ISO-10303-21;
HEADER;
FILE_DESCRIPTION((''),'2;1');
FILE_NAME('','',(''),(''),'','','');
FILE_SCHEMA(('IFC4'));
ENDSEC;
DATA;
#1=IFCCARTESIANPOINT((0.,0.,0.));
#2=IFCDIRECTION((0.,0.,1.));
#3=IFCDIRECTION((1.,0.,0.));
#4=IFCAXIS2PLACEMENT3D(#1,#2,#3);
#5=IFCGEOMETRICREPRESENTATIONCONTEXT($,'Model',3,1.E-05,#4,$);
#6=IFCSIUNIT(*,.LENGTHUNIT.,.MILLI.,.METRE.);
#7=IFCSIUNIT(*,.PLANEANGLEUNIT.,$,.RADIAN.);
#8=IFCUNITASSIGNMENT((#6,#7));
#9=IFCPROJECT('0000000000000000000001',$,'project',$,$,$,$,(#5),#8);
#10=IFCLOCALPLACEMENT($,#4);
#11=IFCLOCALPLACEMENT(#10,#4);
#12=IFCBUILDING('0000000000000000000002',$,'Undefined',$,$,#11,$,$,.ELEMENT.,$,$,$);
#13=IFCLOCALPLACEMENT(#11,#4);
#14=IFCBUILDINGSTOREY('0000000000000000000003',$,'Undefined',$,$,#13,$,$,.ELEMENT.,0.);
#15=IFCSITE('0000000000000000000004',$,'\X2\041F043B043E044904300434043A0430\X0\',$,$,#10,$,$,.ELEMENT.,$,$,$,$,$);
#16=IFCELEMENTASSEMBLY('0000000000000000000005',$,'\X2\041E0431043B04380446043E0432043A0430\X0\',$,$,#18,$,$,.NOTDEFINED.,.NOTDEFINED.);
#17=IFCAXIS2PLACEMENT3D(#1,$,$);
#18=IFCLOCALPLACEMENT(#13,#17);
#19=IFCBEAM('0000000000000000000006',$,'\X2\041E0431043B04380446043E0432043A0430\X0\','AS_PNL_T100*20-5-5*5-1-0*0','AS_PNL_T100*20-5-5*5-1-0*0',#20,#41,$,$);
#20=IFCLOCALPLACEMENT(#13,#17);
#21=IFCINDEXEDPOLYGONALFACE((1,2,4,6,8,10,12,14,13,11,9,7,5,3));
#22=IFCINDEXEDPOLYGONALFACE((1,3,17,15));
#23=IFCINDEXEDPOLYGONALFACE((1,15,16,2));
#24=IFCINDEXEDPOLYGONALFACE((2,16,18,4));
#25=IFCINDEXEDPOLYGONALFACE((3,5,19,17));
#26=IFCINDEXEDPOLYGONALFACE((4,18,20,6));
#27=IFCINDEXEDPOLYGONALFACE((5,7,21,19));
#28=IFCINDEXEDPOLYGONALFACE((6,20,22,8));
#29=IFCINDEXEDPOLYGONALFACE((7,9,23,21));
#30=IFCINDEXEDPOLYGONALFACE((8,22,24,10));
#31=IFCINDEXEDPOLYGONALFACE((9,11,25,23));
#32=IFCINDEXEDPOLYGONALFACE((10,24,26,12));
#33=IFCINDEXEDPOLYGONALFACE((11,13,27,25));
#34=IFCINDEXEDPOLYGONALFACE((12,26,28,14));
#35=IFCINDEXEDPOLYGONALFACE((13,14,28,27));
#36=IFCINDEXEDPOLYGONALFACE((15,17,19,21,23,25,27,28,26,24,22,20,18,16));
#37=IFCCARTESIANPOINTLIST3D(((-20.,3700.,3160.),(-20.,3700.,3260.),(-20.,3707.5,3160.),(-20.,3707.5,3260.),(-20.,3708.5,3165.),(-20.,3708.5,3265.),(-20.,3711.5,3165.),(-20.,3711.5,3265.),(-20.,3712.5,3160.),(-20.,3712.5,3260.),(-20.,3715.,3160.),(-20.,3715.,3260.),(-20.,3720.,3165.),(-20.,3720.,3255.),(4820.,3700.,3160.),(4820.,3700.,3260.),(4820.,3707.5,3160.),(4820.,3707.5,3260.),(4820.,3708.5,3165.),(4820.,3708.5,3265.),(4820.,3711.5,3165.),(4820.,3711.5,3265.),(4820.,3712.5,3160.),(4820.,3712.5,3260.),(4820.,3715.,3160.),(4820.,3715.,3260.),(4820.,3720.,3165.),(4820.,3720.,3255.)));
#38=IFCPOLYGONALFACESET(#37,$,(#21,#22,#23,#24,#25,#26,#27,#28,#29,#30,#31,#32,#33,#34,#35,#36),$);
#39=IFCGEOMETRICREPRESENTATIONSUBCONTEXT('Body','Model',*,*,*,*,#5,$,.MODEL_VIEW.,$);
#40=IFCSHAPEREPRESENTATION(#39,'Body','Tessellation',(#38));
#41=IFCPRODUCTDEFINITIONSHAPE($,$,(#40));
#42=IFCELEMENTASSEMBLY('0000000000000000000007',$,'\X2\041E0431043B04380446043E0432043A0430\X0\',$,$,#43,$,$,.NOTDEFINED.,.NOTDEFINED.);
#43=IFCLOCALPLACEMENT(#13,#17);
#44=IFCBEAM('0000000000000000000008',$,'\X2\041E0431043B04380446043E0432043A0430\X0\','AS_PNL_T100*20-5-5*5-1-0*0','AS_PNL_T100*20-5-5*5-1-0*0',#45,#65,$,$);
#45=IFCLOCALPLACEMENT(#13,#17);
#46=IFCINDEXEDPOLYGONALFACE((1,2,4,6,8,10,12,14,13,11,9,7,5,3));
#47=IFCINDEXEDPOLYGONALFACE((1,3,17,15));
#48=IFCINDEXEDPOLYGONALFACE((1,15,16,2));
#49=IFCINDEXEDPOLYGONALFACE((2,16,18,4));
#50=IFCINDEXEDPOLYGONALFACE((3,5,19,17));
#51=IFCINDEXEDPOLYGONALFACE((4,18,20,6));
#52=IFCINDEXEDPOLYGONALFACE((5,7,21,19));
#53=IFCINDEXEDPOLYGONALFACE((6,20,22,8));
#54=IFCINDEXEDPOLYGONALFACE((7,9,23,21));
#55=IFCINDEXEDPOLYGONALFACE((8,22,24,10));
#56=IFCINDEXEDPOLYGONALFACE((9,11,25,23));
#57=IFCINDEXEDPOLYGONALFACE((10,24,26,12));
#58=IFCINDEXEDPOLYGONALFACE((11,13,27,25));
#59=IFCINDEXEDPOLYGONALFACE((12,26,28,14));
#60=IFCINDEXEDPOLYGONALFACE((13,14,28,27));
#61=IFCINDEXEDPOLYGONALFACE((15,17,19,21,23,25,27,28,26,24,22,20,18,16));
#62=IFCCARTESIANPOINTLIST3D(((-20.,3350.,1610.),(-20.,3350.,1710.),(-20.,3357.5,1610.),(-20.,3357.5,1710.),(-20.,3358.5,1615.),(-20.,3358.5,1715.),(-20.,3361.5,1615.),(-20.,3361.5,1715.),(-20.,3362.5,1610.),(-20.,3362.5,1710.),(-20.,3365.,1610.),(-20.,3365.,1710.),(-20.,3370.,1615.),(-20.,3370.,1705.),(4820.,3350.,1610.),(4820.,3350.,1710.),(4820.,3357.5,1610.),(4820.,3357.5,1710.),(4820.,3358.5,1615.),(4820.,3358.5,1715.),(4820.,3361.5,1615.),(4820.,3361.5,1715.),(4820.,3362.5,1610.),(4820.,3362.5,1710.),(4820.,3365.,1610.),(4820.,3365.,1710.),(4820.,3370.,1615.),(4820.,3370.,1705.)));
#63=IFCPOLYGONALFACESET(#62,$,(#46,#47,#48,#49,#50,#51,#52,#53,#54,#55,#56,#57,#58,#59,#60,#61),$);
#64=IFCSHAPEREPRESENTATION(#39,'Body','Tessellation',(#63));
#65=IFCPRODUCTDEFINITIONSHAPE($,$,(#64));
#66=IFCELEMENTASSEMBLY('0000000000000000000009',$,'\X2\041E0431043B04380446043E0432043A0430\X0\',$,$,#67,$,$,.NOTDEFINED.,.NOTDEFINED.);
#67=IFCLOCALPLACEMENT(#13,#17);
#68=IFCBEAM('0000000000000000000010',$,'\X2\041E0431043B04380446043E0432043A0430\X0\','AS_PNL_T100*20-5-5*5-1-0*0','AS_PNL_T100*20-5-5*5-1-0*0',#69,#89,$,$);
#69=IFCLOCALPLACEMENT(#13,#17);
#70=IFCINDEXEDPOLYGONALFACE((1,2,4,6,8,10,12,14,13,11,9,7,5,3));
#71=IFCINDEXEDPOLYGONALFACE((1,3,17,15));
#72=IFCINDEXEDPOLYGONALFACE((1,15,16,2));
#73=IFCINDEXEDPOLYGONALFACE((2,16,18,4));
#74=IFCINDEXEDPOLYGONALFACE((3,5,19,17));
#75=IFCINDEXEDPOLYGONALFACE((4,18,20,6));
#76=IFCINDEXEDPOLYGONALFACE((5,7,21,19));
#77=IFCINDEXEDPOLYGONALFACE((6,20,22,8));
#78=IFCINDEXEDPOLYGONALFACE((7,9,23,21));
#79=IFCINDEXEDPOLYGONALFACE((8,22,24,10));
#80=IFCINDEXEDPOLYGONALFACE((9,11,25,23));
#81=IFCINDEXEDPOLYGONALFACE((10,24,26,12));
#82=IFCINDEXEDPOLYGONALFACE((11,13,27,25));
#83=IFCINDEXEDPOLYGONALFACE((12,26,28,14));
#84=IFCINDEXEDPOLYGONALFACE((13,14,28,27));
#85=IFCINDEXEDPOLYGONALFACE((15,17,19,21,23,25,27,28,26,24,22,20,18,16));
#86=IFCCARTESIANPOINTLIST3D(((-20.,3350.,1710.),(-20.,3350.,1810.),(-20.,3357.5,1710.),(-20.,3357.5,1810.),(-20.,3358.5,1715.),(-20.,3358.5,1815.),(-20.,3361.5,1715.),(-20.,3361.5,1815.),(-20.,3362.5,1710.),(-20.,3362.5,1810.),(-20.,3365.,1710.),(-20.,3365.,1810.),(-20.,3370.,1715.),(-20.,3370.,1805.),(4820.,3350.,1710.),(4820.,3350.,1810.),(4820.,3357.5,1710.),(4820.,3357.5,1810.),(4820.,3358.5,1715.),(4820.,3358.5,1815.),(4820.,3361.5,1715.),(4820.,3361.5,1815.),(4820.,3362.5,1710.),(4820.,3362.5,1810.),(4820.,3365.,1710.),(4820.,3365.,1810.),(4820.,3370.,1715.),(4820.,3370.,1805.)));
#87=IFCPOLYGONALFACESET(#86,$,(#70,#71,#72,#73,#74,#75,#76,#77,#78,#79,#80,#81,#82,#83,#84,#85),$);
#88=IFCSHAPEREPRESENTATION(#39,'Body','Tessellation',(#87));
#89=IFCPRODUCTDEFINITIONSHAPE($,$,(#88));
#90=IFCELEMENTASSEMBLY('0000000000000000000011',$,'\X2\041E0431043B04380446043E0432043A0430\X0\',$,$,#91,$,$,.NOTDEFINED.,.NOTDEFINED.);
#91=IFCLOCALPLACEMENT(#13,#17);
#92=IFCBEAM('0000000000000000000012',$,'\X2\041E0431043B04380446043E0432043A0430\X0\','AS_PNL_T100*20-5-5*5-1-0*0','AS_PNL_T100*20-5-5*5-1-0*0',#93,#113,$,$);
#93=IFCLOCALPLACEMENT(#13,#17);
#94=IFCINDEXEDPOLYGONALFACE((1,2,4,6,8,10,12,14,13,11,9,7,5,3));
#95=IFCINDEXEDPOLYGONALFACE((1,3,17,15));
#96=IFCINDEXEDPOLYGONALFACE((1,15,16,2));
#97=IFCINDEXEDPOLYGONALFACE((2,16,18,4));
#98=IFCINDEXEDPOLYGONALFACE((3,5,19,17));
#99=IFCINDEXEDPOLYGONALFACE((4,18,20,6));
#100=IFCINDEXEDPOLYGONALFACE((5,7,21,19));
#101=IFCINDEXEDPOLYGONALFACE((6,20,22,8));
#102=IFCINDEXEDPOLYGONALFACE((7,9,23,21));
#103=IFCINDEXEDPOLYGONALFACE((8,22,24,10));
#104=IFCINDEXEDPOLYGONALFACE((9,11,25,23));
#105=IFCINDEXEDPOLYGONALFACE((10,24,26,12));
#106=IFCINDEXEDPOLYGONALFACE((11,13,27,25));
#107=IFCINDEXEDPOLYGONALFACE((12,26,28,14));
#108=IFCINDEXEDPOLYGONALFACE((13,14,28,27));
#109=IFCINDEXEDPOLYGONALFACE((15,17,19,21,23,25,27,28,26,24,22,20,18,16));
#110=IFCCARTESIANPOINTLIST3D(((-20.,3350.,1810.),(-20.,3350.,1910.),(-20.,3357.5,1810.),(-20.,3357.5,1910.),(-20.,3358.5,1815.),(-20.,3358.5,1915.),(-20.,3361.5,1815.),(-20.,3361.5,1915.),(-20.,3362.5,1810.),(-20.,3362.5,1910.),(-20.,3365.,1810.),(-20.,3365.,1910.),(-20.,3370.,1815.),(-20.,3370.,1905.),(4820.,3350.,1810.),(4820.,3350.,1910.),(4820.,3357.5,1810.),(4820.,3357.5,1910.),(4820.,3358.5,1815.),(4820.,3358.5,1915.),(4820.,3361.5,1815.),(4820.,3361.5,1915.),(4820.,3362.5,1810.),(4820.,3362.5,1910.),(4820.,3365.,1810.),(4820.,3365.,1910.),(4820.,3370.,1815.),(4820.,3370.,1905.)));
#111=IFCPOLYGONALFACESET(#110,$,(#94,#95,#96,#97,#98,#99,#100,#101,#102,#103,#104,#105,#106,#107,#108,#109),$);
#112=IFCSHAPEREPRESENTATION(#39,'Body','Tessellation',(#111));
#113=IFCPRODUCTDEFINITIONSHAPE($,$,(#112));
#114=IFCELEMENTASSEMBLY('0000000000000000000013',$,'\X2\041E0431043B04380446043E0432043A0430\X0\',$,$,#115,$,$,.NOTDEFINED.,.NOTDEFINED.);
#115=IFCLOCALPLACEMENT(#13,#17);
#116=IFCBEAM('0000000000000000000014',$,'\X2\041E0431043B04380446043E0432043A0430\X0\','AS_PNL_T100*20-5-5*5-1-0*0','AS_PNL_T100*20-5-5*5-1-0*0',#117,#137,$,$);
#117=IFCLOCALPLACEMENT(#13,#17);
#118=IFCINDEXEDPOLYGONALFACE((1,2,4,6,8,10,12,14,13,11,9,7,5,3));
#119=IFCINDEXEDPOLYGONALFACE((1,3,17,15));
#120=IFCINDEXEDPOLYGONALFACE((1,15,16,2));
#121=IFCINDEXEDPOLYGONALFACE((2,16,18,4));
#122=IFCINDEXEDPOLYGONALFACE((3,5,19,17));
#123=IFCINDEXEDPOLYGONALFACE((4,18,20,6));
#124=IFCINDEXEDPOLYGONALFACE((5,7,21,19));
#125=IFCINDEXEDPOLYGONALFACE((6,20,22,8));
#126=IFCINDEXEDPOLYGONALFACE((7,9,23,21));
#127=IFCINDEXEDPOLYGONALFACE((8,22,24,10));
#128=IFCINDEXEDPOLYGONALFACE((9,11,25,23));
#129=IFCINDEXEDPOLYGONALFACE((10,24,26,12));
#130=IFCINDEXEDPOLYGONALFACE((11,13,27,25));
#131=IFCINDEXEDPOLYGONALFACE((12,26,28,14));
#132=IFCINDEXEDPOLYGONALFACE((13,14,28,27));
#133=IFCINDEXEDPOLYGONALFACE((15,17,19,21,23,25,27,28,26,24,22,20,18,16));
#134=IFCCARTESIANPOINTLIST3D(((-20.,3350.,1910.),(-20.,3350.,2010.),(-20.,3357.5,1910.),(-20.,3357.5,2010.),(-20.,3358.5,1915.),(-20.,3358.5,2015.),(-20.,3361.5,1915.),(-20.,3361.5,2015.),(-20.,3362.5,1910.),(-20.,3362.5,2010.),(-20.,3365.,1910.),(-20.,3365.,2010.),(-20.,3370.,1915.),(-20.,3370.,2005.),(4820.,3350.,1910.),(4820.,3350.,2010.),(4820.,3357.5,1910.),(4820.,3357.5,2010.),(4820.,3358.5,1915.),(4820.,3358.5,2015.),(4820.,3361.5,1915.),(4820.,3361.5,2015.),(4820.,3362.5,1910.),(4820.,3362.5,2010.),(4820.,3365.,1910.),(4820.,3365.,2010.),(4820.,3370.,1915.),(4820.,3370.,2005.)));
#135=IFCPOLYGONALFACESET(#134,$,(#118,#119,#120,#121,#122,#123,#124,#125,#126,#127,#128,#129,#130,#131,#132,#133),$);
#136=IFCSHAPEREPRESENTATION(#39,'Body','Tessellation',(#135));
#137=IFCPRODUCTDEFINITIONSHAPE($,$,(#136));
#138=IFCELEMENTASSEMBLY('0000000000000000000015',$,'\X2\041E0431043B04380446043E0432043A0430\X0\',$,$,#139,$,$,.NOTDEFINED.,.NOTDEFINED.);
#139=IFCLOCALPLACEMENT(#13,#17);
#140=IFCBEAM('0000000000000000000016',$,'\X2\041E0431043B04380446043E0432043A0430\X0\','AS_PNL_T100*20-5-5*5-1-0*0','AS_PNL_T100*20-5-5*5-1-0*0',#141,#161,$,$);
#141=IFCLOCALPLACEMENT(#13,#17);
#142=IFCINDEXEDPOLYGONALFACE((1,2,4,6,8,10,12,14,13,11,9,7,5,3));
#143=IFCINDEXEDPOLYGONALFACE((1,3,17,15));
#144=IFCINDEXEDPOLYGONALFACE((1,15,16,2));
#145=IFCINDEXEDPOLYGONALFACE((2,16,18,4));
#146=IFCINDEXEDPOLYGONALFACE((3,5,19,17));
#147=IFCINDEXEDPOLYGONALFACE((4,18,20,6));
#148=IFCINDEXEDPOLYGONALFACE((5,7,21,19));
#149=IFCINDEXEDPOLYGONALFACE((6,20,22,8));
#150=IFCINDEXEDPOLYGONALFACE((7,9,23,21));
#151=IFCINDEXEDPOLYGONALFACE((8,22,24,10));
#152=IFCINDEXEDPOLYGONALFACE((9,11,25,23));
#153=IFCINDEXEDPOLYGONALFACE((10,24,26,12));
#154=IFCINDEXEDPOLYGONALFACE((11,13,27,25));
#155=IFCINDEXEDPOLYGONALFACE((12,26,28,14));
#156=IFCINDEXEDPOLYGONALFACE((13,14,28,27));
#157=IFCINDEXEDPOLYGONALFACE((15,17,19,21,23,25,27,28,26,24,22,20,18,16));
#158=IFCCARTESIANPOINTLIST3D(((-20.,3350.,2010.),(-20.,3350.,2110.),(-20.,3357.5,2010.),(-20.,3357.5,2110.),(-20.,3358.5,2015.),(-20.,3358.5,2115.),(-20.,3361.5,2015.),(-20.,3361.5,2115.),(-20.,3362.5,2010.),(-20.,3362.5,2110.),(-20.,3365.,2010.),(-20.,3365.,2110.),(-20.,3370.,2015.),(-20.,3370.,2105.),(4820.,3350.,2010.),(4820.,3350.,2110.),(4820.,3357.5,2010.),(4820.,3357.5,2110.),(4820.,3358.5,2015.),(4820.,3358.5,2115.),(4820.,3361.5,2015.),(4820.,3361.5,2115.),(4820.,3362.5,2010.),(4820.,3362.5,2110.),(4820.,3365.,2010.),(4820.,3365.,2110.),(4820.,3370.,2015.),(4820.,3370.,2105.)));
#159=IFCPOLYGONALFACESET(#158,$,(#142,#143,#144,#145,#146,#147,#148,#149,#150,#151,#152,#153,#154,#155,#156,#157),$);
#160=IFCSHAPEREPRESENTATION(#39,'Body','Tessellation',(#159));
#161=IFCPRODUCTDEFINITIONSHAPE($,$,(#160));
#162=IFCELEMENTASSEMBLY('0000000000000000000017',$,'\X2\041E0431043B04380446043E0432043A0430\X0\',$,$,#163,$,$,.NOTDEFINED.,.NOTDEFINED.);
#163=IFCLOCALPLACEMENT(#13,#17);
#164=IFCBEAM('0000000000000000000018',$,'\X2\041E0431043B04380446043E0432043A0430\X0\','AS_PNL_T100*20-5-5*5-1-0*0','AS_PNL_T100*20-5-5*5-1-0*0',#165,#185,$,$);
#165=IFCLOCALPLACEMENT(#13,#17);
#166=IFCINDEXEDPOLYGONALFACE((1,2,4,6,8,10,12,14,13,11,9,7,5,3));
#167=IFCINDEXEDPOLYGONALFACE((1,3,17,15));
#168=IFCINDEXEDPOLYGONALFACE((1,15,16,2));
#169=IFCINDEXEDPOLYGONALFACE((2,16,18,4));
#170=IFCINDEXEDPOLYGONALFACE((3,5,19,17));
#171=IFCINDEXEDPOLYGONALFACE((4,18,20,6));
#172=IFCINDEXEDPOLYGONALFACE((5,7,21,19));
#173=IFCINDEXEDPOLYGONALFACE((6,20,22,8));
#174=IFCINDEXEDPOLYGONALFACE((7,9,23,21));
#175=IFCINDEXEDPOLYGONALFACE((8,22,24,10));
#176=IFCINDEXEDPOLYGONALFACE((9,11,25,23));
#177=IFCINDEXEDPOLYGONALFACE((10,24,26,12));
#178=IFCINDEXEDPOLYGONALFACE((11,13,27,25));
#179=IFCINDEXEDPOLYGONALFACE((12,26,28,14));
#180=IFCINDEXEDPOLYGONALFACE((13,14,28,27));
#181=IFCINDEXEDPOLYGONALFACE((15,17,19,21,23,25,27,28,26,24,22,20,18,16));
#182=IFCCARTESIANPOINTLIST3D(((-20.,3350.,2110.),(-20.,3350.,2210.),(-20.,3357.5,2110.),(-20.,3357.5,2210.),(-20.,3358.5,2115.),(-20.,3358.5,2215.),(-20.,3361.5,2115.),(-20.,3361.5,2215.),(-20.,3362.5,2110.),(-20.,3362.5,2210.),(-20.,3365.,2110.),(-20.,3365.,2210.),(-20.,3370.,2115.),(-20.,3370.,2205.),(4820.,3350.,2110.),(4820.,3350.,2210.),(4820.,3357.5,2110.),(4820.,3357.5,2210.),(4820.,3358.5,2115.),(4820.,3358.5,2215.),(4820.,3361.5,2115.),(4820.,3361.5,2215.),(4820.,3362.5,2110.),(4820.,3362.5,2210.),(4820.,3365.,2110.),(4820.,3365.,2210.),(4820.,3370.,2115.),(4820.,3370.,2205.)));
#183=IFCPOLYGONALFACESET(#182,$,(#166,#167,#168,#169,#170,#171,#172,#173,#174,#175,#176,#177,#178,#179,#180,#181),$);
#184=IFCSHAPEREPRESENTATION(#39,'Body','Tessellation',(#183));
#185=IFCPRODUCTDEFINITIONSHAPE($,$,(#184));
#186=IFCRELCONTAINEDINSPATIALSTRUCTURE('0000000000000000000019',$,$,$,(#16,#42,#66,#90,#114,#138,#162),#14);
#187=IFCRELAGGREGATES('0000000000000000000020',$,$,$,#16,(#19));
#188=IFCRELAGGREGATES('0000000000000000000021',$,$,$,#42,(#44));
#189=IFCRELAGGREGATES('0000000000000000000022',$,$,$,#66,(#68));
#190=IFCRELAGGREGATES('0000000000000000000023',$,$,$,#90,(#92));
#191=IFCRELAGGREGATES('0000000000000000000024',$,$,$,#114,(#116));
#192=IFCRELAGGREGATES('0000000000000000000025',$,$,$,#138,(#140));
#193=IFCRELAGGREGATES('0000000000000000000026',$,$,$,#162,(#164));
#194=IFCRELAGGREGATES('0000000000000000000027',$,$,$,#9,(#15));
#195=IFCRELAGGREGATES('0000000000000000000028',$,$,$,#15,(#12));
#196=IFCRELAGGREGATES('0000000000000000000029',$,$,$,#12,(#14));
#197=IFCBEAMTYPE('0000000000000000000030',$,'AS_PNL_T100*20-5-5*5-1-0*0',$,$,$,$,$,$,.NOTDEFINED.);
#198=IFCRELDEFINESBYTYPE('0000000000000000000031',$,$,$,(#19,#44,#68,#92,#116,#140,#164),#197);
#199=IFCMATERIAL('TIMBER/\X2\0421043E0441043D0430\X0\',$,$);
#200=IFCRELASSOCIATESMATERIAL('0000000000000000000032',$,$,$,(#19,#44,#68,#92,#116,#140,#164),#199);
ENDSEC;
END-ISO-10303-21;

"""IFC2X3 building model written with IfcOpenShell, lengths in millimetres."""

from ifc_helpers import new_model, si_unit, frame, origin_with_axes, place, context, subcontext, project, spatial, polyline, outline, extrude, material, type_object, element, aggregate, save


model = new_model("IFC2X3")

# Units and contexts
model_context = context("Model", 3, precision=1e-05, world=origin_with_axes())
body_context = subcontext(model_context, "Body", "Model", "MODEL_VIEW")
ifc_project = project(units=[si_unit("LENGTHUNIT", "METRE", prefix="MILLI"), si_unit("PLANEANGLEUNIT", "RADIAN")], contexts=[model_context])

# Site, building, storey
site_placement = place(None, origin_with_axes())
site = spatial("IfcSite", under=ifc_project, at=site_placement, Name="Площадка", CompositionType="ELEMENT")
building_placement = place(site_placement, origin_with_axes())
building = spatial("IfcBuilding", under=site, at=building_placement, Name="Undefined", CompositionType="ELEMENT")
storey_placement = place(building_placement, origin_with_axes())
storey = spatial("IfcBuildingStorey", under=building, at=storey_placement, Name="Undefined", CompositionType="ELEMENT", Elevation=0.0)

# Shared definitions
ifc_material = material(Name="TIMBER/Сосна")

# Element assemblies, beams
assembly_1_placement = place(storey_placement, origin_with_axes())
assembly_1 = element("IfcElementAssembly", 1, at=assembly_1_placement, inside=storey, Name="Облицовка", AssemblyPlace="NOTDEFINED", PredefinedType="NOTDEFINED")
beam_type_1 = type_object("IfcBeamType", Name="AS_PNL_T100*20-5-5*5-1-0*0", PredefinedType="NOTDEFINED")
beam_1_placement = place(assembly_1_placement, frame((4820.0, 3710.0, 3210.0), z_axis=(0.0, 0.0, 1.0), x_axis=(-1.0, 0.0, 0.0)))
beam_1 = element("IfcBeam", 2, at=beam_1_placement, type_object=beam_type_1, material=ifc_material, Name="Облицовка", Description="AS_PNL_T100*20-5-5*5-1-0*0", ObjectType="AS_PNL_T100*20-5-5*5-1-0*0", context=body_context, shape_type="SweptSolid", body=[
    extrude(outline(polyline([(-2.5, -50.0), (-10.0, -50.0), (-10.0, 50.0), (-2.5, 50.0), (-1.5, 55.0), (1.5, 55.0), (2.5, 50.0), (5.0, 50.0), (10.0, 45.0), (10.0, -45.0), (5.0, -50.0), (2.5, -50.0), (1.5, -45.0), (-1.5, -45.0), (-2.5, -50.0)])), frame((4840.0, 0.0, 0.0), z_axis=(-1.0, 0.0, 0.0), x_axis=(0.0, -1.0, 0.0)), (0.0, 0.0, 1.0), 4840.0),
])
aggregate(assembly_1, [beam_1])
assembly_2_placement = place(storey_placement, origin_with_axes())
assembly_2 = element("IfcElementAssembly", 3, at=assembly_2_placement, inside=storey, Name="Облицовка", AssemblyPlace="NOTDEFINED", PredefinedType="NOTDEFINED")
beam_2_placement = place(assembly_2_placement, frame((4820.0, 3360.0, 1660.0), z_axis=(0.0, 0.0, 1.0), x_axis=(-1.0, 0.0, 0.0)))
beam_2 = element("IfcBeam", 4, at=beam_2_placement, type_object=beam_type_1, material=ifc_material, Name="Облицовка", Description="AS_PNL_T100*20-5-5*5-1-0*0", ObjectType="AS_PNL_T100*20-5-5*5-1-0*0", context=body_context, shape_type="SweptSolid", body=[
    extrude(outline(polyline([(-2.5, -50.0), (-10.0, -50.0), (-10.0, 50.0), (-2.5, 50.0), (-1.5, 55.0), (1.5, 55.0), (2.5, 50.0), (5.0, 50.0), (10.0, 45.0), (10.0, -45.0), (5.0, -50.0), (2.5, -50.0), (1.5, -45.0), (-1.5, -45.0), (-2.5, -50.0)])), frame((4840.0, 0.0, 0.0), z_axis=(-1.0, 0.0, 0.0), x_axis=(0.0, -1.0, 0.0)), (0.0, 0.0, 1.0), 4840.0),
])
aggregate(assembly_2, [beam_2])
assembly_3_placement = place(storey_placement, origin_with_axes())
assembly_3 = element("IfcElementAssembly", 5, at=assembly_3_placement, inside=storey, Name="Облицовка", AssemblyPlace="NOTDEFINED", PredefinedType="NOTDEFINED")
beam_3_placement = place(assembly_3_placement, frame((4820.0, 3360.0, 1760.0), z_axis=(0.0, 0.0, 1.0), x_axis=(-1.0, 0.0, 0.0)))
beam_3 = element("IfcBeam", 6, at=beam_3_placement, type_object=beam_type_1, material=ifc_material, Name="Облицовка", Description="AS_PNL_T100*20-5-5*5-1-0*0", ObjectType="AS_PNL_T100*20-5-5*5-1-0*0", context=body_context, shape_type="SweptSolid", body=[
    extrude(outline(polyline([(-2.5, -50.0), (-10.0, -50.0), (-10.0, 50.0), (-2.5, 50.0), (-1.5, 55.0), (1.5, 55.0), (2.5, 50.0), (5.0, 50.0), (10.0, 45.0), (10.0, -45.0), (5.0, -50.0), (2.5, -50.0), (1.5, -45.0), (-1.5, -45.0), (-2.5, -50.0)])), frame((4840.0, 0.0, 0.0), z_axis=(-1.0, 0.0, 0.0), x_axis=(0.0, -1.0, 0.0)), (0.0, 0.0, 1.0), 4840.0),
])
aggregate(assembly_3, [beam_3])
assembly_4_placement = place(storey_placement, origin_with_axes())
assembly_4 = element("IfcElementAssembly", 7, at=assembly_4_placement, inside=storey, Name="Облицовка", AssemblyPlace="NOTDEFINED", PredefinedType="NOTDEFINED")
beam_4_placement = place(assembly_4_placement, frame((4820.0, 3360.0, 1860.0), z_axis=(0.0, 0.0, 1.0), x_axis=(-1.0, 0.0, 0.0)))
beam_4 = element("IfcBeam", 8, at=beam_4_placement, type_object=beam_type_1, material=ifc_material, Name="Облицовка", Description="AS_PNL_T100*20-5-5*5-1-0*0", ObjectType="AS_PNL_T100*20-5-5*5-1-0*0", context=body_context, shape_type="SweptSolid", body=[
    extrude(outline(polyline([(-2.5, -50.0), (-10.0, -50.0), (-10.0, 50.0), (-2.5, 50.0), (-1.5, 55.0), (1.5, 55.0), (2.5, 50.0), (5.0, 50.0), (10.0, 45.0), (10.0, -45.0), (5.0, -50.0), (2.5, -50.0), (1.5, -45.0), (-1.5, -45.0), (-2.5, -50.0)])), frame((4840.0, 0.0, 0.0), z_axis=(-1.0, 0.0, 0.0), x_axis=(0.0, -1.0, 0.0)), (0.0, 0.0, 1.0), 4840.0),
])
aggregate(assembly_4, [beam_4])
assembly_5_placement = place(storey_placement, origin_with_axes())
assembly_5 = element("IfcElementAssembly", 9, at=assembly_5_placement, inside=storey, Name="Облицовка", AssemblyPlace="NOTDEFINED", PredefinedType="NOTDEFINED")
beam_5_placement = place(assembly_5_placement, frame((4820.0, 3360.0, 1960.0), z_axis=(0.0, 0.0, 1.0), x_axis=(-1.0, 0.0, 0.0)))
beam_5 = element("IfcBeam", 10, at=beam_5_placement, type_object=beam_type_1, material=ifc_material, Name="Облицовка", Description="AS_PNL_T100*20-5-5*5-1-0*0", ObjectType="AS_PNL_T100*20-5-5*5-1-0*0", context=body_context, shape_type="SweptSolid", body=[
    extrude(outline(polyline([(-2.5, -50.0), (-10.0, -50.0), (-10.0, 50.0), (-2.5, 50.0), (-1.5, 55.0), (1.5, 55.0), (2.5, 50.0), (5.0, 50.0), (10.0, 45.0), (10.0, -45.0), (5.0, -50.0), (2.5, -50.0), (1.5, -45.0), (-1.5, -45.0), (-2.5, -50.0)])), frame((4840.0, 0.0, 0.0), z_axis=(-1.0, 0.0, 0.0), x_axis=(0.0, -1.0, 0.0)), (0.0, 0.0, 1.0), 4840.0),
])
aggregate(assembly_5, [beam_5])
assembly_6_placement = place(storey_placement, origin_with_axes())
assembly_6 = element("IfcElementAssembly", 11, at=assembly_6_placement, inside=storey, Name="Облицовка", AssemblyPlace="NOTDEFINED", PredefinedType="NOTDEFINED")
beam_6_placement = place(assembly_6_placement, frame((4820.0, 3360.0, 2060.0), z_axis=(0.0, 0.0, 1.0), x_axis=(-1.0, 0.0, 0.0)))
beam_6 = element("IfcBeam", 12, at=beam_6_placement, type_object=beam_type_1, material=ifc_material, Name="Облицовка", Description="AS_PNL_T100*20-5-5*5-1-0*0", ObjectType="AS_PNL_T100*20-5-5*5-1-0*0", context=body_context, shape_type="SweptSolid", body=[
    extrude(outline(polyline([(-2.5, -50.0), (-10.0, -50.0), (-10.0, 50.0), (-2.5, 50.0), (-1.5, 55.0), (1.5, 55.0), (2.5, 50.0), (5.0, 50.0), (10.0, 45.0), (10.0, -45.0), (5.0, -50.0), (2.5, -50.0), (1.5, -45.0), (-1.5, -45.0), (-2.5, -50.0)])), frame((4840.0, 0.0, 0.0), z_axis=(-1.0, 0.0, 0.0), x_axis=(0.0, -1.0, 0.0)), (0.0, 0.0, 1.0), 4840.0),
])
aggregate(assembly_6, [beam_6])
assembly_7_placement = place(storey_placement, origin_with_axes())
assembly_7 = element("IfcElementAssembly", 13, at=assembly_7_placement, inside=storey, Name="Облицовка", AssemblyPlace="NOTDEFINED", PredefinedType="NOTDEFINED")
beam_7_placement = place(assembly_7_placement, frame((4820.0, 3360.0, 2160.0), z_axis=(0.0, 0.0, 1.0), x_axis=(-1.0, 0.0, 0.0)))
beam_7 = element("IfcBeam", 14, at=beam_7_placement, type_object=beam_type_1, material=ifc_material, Name="Облицовка", Description="AS_PNL_T100*20-5-5*5-1-0*0", ObjectType="AS_PNL_T100*20-5-5*5-1-0*0", context=body_context, shape_type="SweptSolid", body=[
    extrude(outline(polyline([(-2.5, -50.0), (-10.0, -50.0), (-10.0, 50.0), (-2.5, 50.0), (-1.5, 55.0), (1.5, 55.0), (2.5, 50.0), (5.0, 50.0), (10.0, 45.0), (10.0, -45.0), (5.0, -50.0), (2.5, -50.0), (1.5, -45.0), (-1.5, -45.0), (-2.5, -50.0)])), frame((4840.0, 0.0, 0.0), z_axis=(-1.0, 0.0, 0.0), x_axis=(0.0, -1.0, 0.0)), (0.0, 0.0, 1.0), 4840.0),
])
aggregate(assembly_7, [beam_7])

save(model, "model.ifc")
